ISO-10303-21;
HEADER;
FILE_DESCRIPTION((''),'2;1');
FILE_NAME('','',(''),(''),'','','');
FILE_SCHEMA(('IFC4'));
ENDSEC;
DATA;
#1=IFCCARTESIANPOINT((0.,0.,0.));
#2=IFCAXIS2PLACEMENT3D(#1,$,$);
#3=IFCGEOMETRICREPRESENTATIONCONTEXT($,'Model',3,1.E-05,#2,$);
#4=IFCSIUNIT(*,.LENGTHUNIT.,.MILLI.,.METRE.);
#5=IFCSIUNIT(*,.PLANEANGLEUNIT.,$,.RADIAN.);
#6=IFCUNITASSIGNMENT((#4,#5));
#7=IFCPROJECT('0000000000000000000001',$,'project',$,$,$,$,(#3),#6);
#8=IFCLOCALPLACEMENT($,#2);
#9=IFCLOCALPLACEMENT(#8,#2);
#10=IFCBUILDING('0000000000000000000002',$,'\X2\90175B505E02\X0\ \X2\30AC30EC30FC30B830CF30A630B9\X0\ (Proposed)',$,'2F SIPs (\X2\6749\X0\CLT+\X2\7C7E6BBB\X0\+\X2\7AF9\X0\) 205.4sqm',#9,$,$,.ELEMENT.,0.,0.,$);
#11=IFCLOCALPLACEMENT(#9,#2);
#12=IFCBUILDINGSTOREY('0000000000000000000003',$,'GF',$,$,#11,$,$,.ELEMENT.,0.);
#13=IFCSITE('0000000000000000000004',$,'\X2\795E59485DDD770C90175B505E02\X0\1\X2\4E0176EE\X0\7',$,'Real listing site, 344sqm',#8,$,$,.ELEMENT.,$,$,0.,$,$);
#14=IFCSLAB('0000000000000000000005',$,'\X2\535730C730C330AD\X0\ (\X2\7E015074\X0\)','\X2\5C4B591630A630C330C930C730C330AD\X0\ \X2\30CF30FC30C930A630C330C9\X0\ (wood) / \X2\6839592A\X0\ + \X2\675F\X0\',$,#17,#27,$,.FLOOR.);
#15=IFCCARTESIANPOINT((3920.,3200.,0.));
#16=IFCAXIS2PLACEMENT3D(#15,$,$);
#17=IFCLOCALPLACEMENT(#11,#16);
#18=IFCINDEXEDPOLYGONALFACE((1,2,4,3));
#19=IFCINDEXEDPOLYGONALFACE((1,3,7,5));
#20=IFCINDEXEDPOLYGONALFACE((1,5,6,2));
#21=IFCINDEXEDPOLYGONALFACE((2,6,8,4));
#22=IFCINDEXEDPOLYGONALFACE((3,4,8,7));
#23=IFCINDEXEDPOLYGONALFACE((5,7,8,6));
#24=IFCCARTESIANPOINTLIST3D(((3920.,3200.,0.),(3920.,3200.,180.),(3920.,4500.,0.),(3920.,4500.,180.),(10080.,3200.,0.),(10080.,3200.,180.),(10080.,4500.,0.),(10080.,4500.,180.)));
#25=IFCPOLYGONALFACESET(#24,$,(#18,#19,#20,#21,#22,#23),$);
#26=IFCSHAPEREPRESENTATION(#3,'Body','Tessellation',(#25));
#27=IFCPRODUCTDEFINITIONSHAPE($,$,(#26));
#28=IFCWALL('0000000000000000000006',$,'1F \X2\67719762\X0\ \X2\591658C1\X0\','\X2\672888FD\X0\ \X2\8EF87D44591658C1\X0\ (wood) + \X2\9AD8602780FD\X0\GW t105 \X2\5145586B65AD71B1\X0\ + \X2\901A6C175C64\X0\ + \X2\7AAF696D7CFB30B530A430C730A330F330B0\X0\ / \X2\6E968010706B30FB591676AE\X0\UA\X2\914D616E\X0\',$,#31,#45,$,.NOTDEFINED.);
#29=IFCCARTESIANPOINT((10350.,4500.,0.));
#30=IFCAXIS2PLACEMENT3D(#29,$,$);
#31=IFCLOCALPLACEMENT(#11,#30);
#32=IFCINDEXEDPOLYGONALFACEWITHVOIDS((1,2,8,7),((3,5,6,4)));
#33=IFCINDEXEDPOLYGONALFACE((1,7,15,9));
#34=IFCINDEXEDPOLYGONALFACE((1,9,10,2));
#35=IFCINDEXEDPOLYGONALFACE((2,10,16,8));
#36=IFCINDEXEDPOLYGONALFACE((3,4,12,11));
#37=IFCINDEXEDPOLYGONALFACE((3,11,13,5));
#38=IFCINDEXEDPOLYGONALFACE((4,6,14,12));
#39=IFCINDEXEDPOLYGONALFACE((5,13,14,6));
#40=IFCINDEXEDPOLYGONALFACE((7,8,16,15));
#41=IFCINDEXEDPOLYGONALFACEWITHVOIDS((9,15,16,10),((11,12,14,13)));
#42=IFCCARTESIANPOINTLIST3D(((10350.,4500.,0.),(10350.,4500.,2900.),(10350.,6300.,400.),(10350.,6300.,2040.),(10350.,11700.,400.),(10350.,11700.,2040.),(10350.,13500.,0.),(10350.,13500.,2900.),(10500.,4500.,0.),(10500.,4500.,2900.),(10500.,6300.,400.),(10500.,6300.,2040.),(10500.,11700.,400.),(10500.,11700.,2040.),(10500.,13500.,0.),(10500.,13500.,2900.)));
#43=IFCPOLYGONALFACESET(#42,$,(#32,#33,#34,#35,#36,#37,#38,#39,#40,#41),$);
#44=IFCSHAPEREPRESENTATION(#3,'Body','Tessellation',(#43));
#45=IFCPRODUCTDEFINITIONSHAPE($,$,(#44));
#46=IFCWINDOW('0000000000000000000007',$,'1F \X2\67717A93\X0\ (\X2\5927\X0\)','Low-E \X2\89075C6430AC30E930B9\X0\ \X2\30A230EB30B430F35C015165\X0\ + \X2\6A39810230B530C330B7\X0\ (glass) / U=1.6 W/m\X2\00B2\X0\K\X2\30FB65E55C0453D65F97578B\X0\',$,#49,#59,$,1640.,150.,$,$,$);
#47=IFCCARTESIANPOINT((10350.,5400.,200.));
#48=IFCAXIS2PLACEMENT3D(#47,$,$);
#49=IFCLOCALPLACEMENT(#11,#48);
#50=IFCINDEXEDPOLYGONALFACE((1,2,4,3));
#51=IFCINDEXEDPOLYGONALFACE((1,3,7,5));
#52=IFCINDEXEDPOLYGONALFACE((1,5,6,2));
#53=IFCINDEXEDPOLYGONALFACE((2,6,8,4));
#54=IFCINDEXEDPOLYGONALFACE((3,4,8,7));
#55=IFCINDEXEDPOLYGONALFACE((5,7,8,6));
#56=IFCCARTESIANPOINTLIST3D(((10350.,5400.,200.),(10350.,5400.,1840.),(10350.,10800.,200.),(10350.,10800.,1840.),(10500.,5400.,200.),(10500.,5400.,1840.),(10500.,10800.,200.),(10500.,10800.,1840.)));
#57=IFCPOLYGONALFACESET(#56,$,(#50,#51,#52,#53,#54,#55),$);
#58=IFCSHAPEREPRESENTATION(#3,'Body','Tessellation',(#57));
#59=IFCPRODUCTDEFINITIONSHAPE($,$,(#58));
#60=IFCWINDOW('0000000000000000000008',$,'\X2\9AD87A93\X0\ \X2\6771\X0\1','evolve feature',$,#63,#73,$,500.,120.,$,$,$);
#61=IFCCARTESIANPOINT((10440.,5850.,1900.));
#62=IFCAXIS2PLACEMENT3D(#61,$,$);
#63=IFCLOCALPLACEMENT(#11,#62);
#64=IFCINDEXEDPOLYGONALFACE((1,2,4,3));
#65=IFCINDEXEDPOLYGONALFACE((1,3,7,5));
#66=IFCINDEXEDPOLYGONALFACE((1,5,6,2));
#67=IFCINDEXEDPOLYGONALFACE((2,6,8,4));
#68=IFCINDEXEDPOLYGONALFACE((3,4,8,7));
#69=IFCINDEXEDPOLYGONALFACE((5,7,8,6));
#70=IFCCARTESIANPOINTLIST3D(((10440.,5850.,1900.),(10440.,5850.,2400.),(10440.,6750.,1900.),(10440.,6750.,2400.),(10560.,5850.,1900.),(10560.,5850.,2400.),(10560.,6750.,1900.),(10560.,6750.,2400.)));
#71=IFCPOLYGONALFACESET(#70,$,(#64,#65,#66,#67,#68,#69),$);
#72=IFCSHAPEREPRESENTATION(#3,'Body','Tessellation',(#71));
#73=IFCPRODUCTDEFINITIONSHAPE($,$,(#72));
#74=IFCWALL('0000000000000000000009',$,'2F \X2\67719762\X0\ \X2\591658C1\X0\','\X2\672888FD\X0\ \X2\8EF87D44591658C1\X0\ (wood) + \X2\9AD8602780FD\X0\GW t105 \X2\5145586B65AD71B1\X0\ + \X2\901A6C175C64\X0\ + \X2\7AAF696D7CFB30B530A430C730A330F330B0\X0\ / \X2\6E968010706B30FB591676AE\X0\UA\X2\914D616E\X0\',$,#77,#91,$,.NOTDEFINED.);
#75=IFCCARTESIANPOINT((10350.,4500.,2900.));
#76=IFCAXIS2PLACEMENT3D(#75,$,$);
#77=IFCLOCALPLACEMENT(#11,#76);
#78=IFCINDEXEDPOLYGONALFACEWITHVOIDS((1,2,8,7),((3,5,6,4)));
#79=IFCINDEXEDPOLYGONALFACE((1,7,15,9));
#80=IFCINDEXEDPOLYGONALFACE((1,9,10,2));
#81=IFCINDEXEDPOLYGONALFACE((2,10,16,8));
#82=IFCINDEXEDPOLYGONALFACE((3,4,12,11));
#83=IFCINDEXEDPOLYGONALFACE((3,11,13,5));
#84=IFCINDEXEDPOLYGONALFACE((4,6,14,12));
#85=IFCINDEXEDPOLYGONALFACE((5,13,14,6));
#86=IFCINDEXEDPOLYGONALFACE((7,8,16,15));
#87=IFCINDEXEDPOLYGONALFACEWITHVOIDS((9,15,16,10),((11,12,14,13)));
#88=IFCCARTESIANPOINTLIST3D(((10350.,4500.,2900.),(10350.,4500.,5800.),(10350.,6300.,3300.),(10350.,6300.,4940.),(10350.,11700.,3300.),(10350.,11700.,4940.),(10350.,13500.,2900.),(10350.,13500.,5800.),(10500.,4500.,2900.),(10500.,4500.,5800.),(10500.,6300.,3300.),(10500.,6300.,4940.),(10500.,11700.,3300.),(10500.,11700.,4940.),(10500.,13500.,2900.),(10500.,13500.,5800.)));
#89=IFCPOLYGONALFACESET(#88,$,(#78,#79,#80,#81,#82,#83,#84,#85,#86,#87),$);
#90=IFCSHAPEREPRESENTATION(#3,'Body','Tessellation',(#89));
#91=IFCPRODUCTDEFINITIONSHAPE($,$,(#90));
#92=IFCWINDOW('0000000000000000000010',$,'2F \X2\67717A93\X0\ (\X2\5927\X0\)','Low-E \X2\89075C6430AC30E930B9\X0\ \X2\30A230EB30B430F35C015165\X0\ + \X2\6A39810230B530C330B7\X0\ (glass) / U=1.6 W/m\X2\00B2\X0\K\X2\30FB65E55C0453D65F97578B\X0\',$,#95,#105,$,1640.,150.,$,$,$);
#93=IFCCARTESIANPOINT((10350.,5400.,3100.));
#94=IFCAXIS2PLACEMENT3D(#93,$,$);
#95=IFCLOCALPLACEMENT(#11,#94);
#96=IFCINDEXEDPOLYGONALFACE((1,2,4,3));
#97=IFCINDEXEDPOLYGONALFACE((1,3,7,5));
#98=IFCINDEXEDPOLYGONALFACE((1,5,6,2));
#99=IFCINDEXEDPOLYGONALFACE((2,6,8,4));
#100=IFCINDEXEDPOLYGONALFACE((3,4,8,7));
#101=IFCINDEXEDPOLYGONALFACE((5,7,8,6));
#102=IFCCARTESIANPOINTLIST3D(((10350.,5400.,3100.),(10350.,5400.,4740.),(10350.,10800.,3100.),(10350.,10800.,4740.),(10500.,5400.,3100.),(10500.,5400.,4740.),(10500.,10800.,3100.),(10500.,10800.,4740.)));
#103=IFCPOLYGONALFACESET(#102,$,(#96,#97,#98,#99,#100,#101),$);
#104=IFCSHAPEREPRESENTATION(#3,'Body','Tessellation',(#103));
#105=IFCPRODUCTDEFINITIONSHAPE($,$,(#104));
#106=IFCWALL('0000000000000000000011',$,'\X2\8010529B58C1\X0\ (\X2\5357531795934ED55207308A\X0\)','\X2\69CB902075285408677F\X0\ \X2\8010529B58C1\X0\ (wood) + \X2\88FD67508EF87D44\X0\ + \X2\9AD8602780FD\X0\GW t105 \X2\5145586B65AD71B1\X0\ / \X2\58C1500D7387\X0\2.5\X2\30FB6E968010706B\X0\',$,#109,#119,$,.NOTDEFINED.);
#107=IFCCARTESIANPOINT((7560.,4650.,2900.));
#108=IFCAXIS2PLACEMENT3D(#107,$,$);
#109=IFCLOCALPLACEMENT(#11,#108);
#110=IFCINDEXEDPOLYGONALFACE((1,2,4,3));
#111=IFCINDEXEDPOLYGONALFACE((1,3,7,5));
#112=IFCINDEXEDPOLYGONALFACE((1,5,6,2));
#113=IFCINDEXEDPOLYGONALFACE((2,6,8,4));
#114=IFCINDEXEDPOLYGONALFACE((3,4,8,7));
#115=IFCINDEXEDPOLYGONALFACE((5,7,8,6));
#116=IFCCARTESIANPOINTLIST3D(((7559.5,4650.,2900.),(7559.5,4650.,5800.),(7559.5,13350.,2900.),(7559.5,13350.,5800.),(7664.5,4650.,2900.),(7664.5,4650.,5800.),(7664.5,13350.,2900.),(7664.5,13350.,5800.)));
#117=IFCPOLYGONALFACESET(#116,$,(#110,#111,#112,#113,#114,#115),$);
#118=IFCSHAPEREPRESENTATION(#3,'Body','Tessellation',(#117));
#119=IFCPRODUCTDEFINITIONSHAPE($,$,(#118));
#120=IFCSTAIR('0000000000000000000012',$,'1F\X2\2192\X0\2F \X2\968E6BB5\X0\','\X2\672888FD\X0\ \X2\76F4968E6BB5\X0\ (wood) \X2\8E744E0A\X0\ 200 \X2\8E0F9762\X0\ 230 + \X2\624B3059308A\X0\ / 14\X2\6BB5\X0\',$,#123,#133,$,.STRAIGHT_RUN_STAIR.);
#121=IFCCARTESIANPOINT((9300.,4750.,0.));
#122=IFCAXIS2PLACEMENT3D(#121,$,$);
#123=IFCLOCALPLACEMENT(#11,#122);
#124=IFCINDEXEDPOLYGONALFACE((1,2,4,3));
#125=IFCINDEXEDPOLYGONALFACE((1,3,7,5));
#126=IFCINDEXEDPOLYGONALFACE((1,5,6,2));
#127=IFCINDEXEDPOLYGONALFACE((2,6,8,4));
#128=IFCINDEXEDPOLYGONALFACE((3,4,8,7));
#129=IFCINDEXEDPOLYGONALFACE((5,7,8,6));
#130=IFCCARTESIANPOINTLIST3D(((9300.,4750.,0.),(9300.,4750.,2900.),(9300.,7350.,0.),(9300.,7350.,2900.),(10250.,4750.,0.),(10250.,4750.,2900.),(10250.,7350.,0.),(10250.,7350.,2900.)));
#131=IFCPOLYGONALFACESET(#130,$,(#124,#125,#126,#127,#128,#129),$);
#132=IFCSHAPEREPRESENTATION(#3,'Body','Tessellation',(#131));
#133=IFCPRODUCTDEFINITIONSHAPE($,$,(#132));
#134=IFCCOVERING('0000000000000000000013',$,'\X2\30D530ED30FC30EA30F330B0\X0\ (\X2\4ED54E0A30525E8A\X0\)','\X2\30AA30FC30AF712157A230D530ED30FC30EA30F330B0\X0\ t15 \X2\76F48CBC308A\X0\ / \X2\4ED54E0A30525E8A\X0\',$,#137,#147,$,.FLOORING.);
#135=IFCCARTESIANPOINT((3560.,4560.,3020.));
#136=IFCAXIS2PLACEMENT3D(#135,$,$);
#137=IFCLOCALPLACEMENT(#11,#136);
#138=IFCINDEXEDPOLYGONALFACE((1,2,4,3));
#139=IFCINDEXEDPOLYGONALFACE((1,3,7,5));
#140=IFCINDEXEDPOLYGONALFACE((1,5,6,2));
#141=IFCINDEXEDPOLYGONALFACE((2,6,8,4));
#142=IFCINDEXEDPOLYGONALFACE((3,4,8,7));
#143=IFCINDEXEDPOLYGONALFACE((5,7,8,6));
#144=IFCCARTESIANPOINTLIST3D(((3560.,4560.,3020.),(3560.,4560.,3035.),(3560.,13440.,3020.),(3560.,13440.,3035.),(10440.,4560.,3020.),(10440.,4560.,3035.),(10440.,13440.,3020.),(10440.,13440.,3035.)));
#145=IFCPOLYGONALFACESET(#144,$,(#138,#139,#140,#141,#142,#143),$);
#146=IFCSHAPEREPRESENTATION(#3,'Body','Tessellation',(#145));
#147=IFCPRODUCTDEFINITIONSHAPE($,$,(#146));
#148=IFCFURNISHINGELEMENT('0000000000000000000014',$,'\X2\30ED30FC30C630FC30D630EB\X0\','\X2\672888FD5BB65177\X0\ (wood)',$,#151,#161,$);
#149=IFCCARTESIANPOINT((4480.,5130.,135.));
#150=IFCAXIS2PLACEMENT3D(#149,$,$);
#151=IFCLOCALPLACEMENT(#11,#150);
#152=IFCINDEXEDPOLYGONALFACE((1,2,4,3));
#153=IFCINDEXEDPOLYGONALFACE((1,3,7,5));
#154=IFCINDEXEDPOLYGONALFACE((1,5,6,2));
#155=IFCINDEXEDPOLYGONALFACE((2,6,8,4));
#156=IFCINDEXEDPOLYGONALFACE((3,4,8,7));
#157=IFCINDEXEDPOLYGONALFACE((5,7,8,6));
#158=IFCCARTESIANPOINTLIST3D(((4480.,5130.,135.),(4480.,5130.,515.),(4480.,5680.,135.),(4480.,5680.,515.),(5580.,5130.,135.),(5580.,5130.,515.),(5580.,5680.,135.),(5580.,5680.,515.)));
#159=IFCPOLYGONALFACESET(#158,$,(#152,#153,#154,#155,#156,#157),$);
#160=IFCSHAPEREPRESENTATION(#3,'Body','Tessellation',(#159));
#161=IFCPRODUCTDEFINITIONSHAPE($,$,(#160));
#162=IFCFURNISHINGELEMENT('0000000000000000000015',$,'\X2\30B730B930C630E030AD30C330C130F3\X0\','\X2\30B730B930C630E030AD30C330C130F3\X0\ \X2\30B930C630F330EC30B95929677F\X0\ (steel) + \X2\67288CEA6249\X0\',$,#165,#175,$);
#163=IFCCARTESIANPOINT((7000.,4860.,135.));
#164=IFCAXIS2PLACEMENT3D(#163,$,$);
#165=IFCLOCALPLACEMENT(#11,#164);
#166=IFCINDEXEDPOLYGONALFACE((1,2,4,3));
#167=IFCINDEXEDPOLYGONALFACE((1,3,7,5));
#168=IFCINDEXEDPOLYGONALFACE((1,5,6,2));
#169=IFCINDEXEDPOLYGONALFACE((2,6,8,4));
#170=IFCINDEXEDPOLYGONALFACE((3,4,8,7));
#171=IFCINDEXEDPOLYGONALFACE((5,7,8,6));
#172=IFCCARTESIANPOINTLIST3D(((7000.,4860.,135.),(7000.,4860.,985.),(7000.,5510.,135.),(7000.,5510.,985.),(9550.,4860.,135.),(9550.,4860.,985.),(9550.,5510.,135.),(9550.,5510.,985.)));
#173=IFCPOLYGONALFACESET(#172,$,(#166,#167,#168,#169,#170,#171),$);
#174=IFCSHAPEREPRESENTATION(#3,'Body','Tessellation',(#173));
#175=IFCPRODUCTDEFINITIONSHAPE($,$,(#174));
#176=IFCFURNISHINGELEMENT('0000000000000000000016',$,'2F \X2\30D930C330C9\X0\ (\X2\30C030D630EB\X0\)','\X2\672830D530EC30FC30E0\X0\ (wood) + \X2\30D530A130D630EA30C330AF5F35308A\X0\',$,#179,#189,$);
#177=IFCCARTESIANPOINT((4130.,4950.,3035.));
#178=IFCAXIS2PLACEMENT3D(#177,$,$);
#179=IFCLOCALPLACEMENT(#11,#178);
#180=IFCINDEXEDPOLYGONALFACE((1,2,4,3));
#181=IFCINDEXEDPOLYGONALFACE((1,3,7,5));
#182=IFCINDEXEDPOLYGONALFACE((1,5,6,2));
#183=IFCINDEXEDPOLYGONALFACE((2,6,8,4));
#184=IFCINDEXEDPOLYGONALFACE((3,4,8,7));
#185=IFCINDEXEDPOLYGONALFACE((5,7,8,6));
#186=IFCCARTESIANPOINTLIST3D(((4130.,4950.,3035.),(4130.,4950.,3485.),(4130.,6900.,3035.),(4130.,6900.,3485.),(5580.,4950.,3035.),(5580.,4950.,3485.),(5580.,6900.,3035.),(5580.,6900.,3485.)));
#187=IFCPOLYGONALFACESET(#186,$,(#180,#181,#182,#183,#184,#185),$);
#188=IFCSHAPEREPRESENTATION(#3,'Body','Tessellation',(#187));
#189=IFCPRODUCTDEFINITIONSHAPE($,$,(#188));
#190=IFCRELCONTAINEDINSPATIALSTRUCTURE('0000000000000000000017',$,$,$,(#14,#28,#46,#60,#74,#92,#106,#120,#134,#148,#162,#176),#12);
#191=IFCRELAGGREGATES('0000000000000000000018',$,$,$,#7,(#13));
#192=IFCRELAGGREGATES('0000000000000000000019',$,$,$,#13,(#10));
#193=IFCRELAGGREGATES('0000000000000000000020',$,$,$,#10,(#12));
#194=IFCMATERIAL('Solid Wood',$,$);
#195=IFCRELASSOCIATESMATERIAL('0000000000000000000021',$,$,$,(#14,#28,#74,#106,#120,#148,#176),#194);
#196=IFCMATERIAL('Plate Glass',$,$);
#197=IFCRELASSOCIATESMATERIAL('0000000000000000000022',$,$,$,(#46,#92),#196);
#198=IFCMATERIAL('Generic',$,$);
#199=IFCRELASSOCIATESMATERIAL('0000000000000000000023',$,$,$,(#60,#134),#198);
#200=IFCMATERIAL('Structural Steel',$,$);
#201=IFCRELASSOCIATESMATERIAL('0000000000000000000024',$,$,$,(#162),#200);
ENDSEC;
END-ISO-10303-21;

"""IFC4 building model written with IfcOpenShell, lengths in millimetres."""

from ifc_helpers import new_model, si_unit, frame, frame_2d, origin, place, context, project, spatial, rectangle, extrude, material, element, fill, save


model = new_model("IFC4")

# Units and contexts
model_context = context("Model", 3, precision=1e-05, world=origin())
ifc_project = project(units=[si_unit("LENGTHUNIT", "METRE", prefix="MILLI"), si_unit("PLANEANGLEUNIT", "RADIAN")], contexts=[model_context])

# Site, building, storey
site_placement = place(None, origin())
site = spatial("IfcSite", under=ifc_project, at=site_placement, Name="神奈川県逗子市1丁目7", ObjectType="Real listing site, 344sqm", CompositionType="ELEMENT", RefElevation=0.0)
building_placement = place(site_placement, origin())
building = spatial("IfcBuilding", under=site, at=building_placement, Name="逗子市 ガレージハウス (Proposed)", ObjectType="2F SIPs (杉CLT+籾殻+竹) 205.4sqm", CompositionType="ELEMENT", ElevationOfRefHeight=0.0, ElevationOfTerrain=0.0)
storey_placement = place(building_placement, origin())
storey = spatial("IfcBuildingStorey", under=building, at=storey_placement, Name="GF", CompositionType="ELEMENT", Elevation=0.0)

# Slab
ifc_material_1 = material(Name="Solid Wood")
slab_placement = place(storey_placement, frame((3920.0, 3200.0, 0.0)))
element("IfcSlab", 1, at=slab_placement, inside=storey, material=ifc_material_1, Name="南デッキ (縁側)", Description="屋外ウッドデッキ ハードウッド (wood) / 根太 + 束", PredefinedType="FLOOR", context=model_context, shape_type="SweptSolid", body=[
    extrude(rectangle(XDim=6160.0, YDim=1300.0, at=frame_2d((3080.0, 650.0))), frame((3920.0, 3200.0, 0.0)), (0.0, 0.0, 1.0), 180.0),
])

# Wall, openings, windows
wall_1_placement = place(storey_placement, frame((10350.0, 4500.0, 0.0)))
wall_1 = element("IfcWall", 2, at=wall_1_placement, inside=storey, material=ifc_material_1, Name="1F 東面 外壁", Description="木製 軸組外壁 (wood) + 高性能GW t105 充填断熱 + 通気層 + 窯業系サイディング / 準耐火・外皮UA配慮", PredefinedType="NOTDEFINED", context=model_context, shape_type="SweptSolid", body=[
    extrude(rectangle(XDim=150.0, YDim=9000.0, at=frame_2d((75.0, 4500.0))), frame((10350.0, 4500.0, 0.0)), (0.0, 0.0, 1.0), 2900.0),
])
opening_1_placement = place(storey_placement, frame((10350.0, 5400.0, 200.0)))
opening_1 = element("IfcOpeningElement", 3, at=opening_1_placement, cuts=wall_1, PredefinedType="NOTDEFINED", context=model_context, shape_type="SweptSolid", body=[
    extrude(rectangle(XDim=150.0, YDim=5400.0, at=frame_2d((75.0, 2700.0))), frame((10350.0, 5400.0, 200.0)), (0.0, 0.0, 1.0), 1640.0),
])
opening_2_placement = place(storey_placement, frame((10440.0, 5850.0, 1900.0)))
opening_2 = element("IfcOpeningElement", 4, at=opening_2_placement, cuts=wall_1, PredefinedType="NOTDEFINED", context=model_context, shape_type="SweptSolid", body=[
    extrude(rectangle(XDim=120.0, YDim=900.0, at=frame_2d((60.0, 450.0))), frame((10440.0, 5850.0, 1900.0)), (0.0, 0.0, 1.0), 500.0),
])
ifc_material_2 = material(Name="Plate Glass")
window_1_placement = place(storey_placement, frame((10350.0, 5400.0, 200.0)))
window_1 = element("IfcWindow", 5, at=window_1_placement, inside=storey, material=ifc_material_2, Name="1F 東窓 (大)", Description="Low-E 複層ガラス アルゴン封入 + 樹脂サッシ (glass) / U=1.6 W/m²K・日射取得型", OverallHeight=1640.0, OverallWidth=150.0, context=model_context, shape_type="SweptSolid", body=[
    extrude(rectangle(XDim=150.0, YDim=5400.0, at=frame_2d((75.0, 2700.0))), frame((10350.0, 5400.0, 200.0)), (0.0, 0.0, 1.0), 1640.0),
])
fill(opening_1, window_1)
ifc_material_3 = material(Name="Generic")
window_2_placement = place(storey_placement, frame((10440.0, 5850.0, 1900.0)))
window_2 = element("IfcWindow", 6, at=window_2_placement, inside=storey, material=ifc_material_3, Name="高窓 東1", Description="evolve feature", OverallHeight=500.0, OverallWidth=120.0, context=model_context, shape_type="SweptSolid", body=[
    extrude(rectangle(XDim=120.0, YDim=900.0, at=frame_2d((60.0, 450.0))), frame((10440.0, 5850.0, 1900.0)), (0.0, 0.0, 1.0), 500.0),
])
fill(opening_2, window_2)

# Wall, opening, window
wall_2_placement = place(storey_placement, frame((10350.0, 4500.0, 2900.0)))
wall_2 = element("IfcWall", 7, at=wall_2_placement, inside=storey, material=ifc_material_1, Name="2F 東面 外壁", Description="木製 軸組外壁 (wood) + 高性能GW t105 充填断熱 + 通気層 + 窯業系サイディング / 準耐火・外皮UA配慮", PredefinedType="NOTDEFINED", context=model_context, shape_type="SweptSolid", body=[
    extrude(rectangle(XDim=150.0, YDim=9000.0, at=frame_2d((75.0, 4500.0))), frame((10350.0, 4500.0, 2900.0)), (0.0, 0.0, 1.0), 2900.0),
])
opening_3_placement = place(storey_placement, frame((10350.0, 5400.0, 3100.0)))
opening_3 = element("IfcOpeningElement", 8, at=opening_3_placement, cuts=wall_2, PredefinedType="NOTDEFINED", context=model_context, shape_type="SweptSolid", body=[
    extrude(rectangle(XDim=150.0, YDim=5400.0, at=frame_2d((75.0, 2700.0))), frame((10350.0, 5400.0, 3100.0)), (0.0, 0.0, 1.0), 1640.0),
])
window_3_placement = place(storey_placement, frame((10350.0, 5400.0, 3100.0)))
window_3 = element("IfcWindow", 9, at=window_3_placement, inside=storey, material=ifc_material_2, Name="2F 東窓 (大)", Description="Low-E 複層ガラス アルゴン封入 + 樹脂サッシ (glass) / U=1.6 W/m²K・日射取得型", OverallHeight=1640.0, OverallWidth=150.0, context=model_context, shape_type="SweptSolid", body=[
    extrude(rectangle(XDim=150.0, YDim=5400.0, at=frame_2d((75.0, 2700.0))), frame((10350.0, 5400.0, 3100.0)), (0.0, 0.0, 1.0), 1640.0),
])
fill(opening_3, window_3)

# Wall
wall_3_placement = place(storey_placement, frame((7560.0, 4650.0, 2900.0)))
element("IfcWall", 10, at=wall_3_placement, inside=storey, material=ifc_material_1, Name="耐力壁 (南北間仕切り)", Description="構造用合板 耐力壁 (wood) + 製材軸組 + 高性能GW t105 充填断熱 / 壁倍率2.5・準耐火", PredefinedType="NOTDEFINED", context=model_context, shape_type="SweptSolid", body=[
    extrude(rectangle(XDim=105.0, YDim=8700.0, at=frame_2d((52.0, 4350.0))), frame((7560.0, 4650.0, 2900.0)), (0.0, 0.0, 1.0), 2900.0),
])

# Stair
stair_placement = place(storey_placement, frame((9300.0, 4750.0, 0.0)))
element("IfcStair", 11, at=stair_placement, inside=storey, material=ifc_material_1, Name="1F→2F 階段", Description="木製 直階段 (wood) 蹴上 200 踏面 230 + 手すり / 14段", PredefinedType="STRAIGHT_RUN_STAIR", context=model_context, shape_type="SweptSolid", body=[
    extrude(rectangle(XDim=950.0, YDim=2600.0, at=frame_2d((475.0, 1300.0))), frame((9300.0, 4750.0, 0.0)), (0.0, 0.0, 1.0), 2900.0),
])

# Covering
covering_placement = place(storey_placement, frame((3560.0, 4560.0, 3020.0)))
element("IfcCovering", 12, at=covering_placement, inside=storey, material=ifc_material_3, Name="フローリング (仕上げ床)", Description="オーク無垢フローリング t15 直貼り / 仕上げ床", PredefinedType="FLOORING", context=model_context, shape_type="SweptSolid", body=[
    extrude(rectangle(XDim=6880.0, YDim=8880.0, at=frame_2d((3440.0, 4440.0))), frame((3560.0, 4560.0, 3020.0)), (0.0, 0.0, 1.0), 15.0),
])

# Furnishing elements
furnishing_1_placement = place(storey_placement, frame((4480.0, 5130.0, 135.0)))
element("IfcFurnishingElement", 13, at=furnishing_1_placement, inside=storey, material=ifc_material_1, Name="ローテーブル", Description="木製家具 (wood)", context=model_context, shape_type="SweptSolid", body=[
    extrude(rectangle(XDim=1100.0, YDim=550.0, at=frame_2d((550.0, 275.0))), frame((4480.0, 5130.0, 135.0)), (0.0, 0.0, 1.0), 380.0),
])
ifc_material_4 = material(Name="Structural Steel")
furnishing_2_placement = place(storey_placement, frame((7000.0, 4860.0, 135.0)))
element("IfcFurnishingElement", 14, at=furnishing_2_placement, inside=storey, material=ifc_material_4, Name="システムキッチン", Description="システムキッチン ステンレス天板 (steel) + 木質扉", context=model_context, shape_type="SweptSolid", body=[
    extrude(rectangle(XDim=2550.0, YDim=650.0, at=frame_2d((1275.0, 325.0))), frame((7000.0, 4860.0, 135.0)), (0.0, 0.0, 1.0), 850.0),
])
furnishing_3_placement = place(storey_placement, frame((4130.0, 4950.0, 3035.0)))
element("IfcFurnishingElement", 15, at=furnishing_3_placement, inside=storey, material=ifc_material_1, Name="2F ベッド (ダブル)", Description="木フレーム (wood) + ファブリック張り", context=model_context, shape_type="SweptSolid", body=[
    extrude(rectangle(XDim=1450.0, YDim=1950.0, at=frame_2d((725.0, 975.0))), frame((4130.0, 4950.0, 3035.0)), (0.0, 0.0, 1.0), 450.0),
])

save(model, "model.ifc")
